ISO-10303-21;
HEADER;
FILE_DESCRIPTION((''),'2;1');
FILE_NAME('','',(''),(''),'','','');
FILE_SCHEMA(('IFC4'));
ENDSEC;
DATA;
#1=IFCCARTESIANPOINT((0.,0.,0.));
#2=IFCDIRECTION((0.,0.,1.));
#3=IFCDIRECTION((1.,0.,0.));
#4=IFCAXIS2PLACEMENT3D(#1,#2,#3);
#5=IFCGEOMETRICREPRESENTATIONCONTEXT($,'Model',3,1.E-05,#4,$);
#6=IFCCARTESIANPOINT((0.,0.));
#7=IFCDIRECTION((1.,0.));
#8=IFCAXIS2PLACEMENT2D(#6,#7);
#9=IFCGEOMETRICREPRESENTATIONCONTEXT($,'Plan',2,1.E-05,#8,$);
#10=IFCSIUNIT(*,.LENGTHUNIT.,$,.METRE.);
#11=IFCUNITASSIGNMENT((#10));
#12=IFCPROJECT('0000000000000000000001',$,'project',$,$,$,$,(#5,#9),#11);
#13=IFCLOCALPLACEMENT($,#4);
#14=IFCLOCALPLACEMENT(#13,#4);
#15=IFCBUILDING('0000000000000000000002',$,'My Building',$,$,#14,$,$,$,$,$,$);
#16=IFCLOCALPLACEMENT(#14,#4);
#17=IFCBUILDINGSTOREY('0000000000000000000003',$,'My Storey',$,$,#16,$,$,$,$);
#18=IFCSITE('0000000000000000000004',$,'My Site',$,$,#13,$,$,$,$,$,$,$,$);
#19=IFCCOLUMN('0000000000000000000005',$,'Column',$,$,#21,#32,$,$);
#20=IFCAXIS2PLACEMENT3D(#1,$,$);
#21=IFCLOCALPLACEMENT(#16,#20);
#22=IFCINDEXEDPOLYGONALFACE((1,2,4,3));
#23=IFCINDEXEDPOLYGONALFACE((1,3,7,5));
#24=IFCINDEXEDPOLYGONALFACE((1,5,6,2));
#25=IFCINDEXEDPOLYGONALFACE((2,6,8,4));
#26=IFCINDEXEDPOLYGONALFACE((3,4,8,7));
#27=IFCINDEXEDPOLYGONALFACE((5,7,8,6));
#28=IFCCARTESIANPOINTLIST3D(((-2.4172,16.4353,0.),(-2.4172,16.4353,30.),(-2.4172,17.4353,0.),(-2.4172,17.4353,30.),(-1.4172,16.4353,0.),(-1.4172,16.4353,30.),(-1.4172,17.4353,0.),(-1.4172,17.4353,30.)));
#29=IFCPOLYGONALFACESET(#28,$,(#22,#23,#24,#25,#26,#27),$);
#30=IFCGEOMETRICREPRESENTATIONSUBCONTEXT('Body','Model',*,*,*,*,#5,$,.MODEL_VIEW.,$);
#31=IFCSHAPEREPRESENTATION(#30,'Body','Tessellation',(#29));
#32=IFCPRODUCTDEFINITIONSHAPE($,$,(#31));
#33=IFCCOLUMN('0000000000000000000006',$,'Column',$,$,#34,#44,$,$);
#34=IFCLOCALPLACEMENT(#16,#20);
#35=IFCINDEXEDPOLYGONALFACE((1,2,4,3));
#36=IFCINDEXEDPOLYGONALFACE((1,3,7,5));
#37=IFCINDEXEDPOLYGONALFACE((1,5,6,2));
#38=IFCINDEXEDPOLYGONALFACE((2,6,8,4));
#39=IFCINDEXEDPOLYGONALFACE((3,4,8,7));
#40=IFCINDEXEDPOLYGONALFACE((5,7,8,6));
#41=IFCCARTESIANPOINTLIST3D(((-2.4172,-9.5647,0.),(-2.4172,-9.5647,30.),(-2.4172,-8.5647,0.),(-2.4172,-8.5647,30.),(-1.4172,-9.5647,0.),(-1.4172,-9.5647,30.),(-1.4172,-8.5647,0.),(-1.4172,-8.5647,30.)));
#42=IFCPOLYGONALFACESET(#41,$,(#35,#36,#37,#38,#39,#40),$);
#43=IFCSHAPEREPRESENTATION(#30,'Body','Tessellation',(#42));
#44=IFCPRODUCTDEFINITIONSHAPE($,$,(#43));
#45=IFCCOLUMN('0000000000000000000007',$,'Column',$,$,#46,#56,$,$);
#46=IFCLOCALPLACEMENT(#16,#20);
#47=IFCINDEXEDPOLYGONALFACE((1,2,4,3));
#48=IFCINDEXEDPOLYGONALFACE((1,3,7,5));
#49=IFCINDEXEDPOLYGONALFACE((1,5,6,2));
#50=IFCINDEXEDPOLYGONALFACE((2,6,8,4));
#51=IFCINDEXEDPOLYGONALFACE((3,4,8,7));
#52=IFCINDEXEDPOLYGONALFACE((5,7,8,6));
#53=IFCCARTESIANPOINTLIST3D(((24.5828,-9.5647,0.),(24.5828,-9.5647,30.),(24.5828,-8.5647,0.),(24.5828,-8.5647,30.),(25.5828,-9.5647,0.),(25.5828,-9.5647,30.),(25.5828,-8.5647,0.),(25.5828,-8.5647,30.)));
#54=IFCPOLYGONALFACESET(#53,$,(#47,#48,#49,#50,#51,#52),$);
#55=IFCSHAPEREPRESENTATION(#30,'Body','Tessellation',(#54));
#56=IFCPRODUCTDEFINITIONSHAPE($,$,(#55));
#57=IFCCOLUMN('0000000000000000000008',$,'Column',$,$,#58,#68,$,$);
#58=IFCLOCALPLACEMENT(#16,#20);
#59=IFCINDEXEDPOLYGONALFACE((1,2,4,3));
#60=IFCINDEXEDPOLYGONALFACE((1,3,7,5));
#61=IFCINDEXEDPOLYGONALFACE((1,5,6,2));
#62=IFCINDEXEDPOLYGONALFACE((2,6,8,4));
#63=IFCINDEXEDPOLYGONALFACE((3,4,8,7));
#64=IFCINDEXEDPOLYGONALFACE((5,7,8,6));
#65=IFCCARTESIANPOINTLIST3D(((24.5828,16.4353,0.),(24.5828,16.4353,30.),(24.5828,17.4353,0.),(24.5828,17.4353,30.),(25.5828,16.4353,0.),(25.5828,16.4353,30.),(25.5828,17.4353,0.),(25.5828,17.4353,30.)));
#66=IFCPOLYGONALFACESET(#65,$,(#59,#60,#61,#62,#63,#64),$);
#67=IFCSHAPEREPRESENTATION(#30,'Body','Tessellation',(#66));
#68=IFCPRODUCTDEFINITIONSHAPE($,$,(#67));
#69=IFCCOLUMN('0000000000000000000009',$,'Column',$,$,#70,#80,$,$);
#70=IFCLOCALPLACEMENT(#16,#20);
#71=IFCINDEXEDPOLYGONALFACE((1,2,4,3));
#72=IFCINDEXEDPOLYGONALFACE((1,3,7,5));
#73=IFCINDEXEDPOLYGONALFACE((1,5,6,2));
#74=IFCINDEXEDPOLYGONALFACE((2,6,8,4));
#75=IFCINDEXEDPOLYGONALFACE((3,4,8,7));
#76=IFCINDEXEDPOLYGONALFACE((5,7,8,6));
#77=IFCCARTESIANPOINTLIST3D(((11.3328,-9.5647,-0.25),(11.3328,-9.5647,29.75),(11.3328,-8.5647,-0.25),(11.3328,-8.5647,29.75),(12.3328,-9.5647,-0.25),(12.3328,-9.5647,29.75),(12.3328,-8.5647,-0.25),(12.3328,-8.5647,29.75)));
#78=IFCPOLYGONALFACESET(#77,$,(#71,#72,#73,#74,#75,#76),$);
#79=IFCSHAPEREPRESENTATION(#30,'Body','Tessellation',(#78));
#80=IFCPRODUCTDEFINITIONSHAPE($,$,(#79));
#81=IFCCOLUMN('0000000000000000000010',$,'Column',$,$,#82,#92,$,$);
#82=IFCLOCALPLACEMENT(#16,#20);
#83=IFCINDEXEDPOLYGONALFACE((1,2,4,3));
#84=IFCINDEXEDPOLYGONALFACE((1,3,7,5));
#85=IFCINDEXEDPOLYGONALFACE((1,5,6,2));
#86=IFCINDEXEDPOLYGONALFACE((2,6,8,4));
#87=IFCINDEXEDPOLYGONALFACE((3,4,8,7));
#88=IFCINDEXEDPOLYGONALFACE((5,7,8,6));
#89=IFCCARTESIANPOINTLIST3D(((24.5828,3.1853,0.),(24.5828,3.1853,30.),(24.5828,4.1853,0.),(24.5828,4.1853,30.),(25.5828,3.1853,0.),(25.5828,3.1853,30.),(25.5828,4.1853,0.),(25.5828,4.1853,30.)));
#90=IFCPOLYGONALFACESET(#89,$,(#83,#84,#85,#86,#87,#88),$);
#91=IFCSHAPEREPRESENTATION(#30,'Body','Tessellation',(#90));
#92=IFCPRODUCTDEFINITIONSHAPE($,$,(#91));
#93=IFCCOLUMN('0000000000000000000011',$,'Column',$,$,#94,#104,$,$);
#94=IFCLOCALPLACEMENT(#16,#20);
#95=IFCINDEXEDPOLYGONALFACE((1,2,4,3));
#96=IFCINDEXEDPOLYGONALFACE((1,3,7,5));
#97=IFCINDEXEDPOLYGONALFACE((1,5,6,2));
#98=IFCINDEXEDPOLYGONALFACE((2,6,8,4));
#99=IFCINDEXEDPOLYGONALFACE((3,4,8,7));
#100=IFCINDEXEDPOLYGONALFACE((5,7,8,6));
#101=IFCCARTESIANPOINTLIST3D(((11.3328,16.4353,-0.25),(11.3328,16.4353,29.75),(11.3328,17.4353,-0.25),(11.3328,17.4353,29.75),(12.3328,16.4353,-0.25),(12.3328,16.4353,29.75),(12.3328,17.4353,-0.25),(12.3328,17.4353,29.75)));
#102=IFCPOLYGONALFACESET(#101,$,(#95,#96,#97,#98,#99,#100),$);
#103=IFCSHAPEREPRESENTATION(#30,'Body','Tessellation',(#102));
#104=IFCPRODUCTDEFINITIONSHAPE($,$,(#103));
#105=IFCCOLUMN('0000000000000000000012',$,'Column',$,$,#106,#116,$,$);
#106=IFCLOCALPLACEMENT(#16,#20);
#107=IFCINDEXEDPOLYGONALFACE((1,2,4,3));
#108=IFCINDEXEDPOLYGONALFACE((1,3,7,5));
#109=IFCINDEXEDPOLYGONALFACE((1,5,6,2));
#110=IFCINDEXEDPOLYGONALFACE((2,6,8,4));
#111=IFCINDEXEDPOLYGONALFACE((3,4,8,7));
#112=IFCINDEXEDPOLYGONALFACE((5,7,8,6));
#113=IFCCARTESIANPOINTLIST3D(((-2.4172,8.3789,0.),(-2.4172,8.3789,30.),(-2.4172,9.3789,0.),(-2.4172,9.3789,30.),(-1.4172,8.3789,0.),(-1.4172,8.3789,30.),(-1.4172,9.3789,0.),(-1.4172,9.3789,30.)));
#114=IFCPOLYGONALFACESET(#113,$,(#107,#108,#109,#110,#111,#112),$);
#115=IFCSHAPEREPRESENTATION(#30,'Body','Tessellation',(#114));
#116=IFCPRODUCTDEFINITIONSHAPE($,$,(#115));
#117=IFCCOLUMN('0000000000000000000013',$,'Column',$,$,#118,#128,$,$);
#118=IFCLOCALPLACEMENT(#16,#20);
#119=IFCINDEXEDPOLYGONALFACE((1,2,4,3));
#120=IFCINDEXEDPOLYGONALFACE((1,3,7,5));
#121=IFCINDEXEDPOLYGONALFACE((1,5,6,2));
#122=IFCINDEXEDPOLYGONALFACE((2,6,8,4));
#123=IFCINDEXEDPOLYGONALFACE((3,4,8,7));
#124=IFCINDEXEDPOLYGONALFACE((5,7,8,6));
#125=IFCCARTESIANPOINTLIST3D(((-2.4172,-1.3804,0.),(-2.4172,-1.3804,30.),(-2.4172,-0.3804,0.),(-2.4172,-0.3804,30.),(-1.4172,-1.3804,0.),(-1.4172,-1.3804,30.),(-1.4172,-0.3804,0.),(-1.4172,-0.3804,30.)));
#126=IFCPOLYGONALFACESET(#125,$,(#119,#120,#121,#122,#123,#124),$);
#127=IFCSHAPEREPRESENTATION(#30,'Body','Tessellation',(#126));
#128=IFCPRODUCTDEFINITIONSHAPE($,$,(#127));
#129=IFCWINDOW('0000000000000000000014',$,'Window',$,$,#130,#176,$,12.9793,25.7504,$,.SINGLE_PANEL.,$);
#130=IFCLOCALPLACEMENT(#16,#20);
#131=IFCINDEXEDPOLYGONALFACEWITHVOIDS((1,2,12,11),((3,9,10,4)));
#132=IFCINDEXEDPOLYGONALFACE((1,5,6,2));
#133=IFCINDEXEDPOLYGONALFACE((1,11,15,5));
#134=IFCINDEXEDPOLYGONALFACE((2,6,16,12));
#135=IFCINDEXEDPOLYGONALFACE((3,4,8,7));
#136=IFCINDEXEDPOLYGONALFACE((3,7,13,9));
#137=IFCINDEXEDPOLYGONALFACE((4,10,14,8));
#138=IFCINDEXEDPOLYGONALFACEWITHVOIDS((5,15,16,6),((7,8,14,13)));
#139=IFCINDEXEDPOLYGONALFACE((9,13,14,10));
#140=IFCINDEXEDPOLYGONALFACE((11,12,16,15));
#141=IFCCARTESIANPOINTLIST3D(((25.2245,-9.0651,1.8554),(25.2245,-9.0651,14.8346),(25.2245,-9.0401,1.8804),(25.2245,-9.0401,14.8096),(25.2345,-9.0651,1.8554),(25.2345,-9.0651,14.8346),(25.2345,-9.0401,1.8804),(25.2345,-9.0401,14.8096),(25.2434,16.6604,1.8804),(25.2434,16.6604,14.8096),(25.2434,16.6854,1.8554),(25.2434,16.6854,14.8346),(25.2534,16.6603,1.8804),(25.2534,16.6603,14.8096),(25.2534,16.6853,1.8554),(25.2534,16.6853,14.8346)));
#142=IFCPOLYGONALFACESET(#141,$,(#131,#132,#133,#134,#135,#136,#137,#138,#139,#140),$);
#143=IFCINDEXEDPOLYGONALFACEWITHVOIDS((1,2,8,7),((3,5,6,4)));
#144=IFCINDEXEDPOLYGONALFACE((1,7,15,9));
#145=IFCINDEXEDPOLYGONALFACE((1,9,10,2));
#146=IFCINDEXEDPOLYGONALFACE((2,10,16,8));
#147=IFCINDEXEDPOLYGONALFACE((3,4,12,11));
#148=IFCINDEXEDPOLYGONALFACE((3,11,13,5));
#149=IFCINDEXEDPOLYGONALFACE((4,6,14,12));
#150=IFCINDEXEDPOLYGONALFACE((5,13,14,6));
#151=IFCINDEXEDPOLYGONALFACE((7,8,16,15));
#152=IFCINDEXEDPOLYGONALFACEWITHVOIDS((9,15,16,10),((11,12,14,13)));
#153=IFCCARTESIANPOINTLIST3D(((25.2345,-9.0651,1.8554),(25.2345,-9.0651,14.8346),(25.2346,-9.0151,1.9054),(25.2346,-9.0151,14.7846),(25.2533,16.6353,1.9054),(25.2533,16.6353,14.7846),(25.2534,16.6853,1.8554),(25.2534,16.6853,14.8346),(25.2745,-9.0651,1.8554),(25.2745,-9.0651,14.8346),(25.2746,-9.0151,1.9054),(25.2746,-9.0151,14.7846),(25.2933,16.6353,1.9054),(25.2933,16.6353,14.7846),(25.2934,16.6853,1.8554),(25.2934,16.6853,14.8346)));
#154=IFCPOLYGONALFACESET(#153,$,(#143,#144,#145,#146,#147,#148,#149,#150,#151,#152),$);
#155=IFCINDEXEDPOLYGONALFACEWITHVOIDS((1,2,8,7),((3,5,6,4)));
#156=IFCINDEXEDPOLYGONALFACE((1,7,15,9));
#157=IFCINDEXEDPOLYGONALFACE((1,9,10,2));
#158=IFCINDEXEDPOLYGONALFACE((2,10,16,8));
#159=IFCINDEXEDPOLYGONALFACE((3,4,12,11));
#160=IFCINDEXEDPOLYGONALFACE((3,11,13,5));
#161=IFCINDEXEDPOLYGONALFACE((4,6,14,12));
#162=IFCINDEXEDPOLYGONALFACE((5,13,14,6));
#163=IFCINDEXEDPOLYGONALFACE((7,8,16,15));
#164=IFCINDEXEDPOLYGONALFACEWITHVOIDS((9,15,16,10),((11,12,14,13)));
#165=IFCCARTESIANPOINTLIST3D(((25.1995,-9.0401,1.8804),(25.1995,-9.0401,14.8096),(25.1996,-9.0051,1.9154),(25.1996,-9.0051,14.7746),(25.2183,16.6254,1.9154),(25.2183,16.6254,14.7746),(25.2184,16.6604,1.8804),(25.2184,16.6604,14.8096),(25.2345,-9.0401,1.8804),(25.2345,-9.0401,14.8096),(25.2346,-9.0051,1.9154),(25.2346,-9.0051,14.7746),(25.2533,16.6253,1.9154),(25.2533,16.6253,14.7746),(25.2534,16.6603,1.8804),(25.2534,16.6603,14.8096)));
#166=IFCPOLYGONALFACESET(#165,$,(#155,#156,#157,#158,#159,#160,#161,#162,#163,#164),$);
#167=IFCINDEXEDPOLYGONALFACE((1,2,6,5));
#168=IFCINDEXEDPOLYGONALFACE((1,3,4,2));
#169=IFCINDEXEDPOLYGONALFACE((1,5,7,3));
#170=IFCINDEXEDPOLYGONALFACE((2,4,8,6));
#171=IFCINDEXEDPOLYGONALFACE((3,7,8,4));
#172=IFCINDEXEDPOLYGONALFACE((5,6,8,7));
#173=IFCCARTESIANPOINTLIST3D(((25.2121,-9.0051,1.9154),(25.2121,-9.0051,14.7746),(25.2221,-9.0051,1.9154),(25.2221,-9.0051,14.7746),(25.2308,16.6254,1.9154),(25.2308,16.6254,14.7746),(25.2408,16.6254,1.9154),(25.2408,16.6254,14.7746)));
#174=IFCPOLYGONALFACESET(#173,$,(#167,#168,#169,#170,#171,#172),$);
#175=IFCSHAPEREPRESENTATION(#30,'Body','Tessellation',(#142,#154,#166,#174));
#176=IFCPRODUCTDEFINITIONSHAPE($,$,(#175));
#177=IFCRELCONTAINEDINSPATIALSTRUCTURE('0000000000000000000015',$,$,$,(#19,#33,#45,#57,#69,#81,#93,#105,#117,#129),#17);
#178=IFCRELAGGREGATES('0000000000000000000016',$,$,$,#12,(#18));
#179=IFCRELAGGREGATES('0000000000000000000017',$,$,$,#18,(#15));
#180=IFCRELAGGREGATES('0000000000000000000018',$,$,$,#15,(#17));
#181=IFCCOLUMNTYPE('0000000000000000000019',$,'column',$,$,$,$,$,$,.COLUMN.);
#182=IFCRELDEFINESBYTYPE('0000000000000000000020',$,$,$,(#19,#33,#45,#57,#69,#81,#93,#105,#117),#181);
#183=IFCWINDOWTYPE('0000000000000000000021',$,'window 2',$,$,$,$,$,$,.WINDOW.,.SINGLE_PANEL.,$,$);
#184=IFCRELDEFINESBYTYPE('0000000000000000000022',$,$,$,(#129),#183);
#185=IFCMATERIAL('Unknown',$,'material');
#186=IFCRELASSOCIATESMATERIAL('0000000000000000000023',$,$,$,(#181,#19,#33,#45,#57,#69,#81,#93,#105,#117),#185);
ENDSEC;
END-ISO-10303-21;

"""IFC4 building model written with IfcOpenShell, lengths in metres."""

from ifc_helpers import new_model, entity, si_unit, frame, origin_with_axes, origin_2d_with_axis, place, context, subcontext, project, spatial, line, indexed_curve, rectangle, outline, extrude, shape, source, transform, mapped, material, material_profile, profile_set, profile_usage, type_object, type_shapes, element, save


model = new_model("IFC4")

# Units and contexts
model_context = context("Model", 3, precision=1e-05, world=origin_with_axes())
plan_context = context("Plan", 2, precision=1e-05, world=origin_2d_with_axis())
body_context_1 = subcontext(model_context, "Body", "Model", "MODEL_VIEW")
body_context_2 = subcontext(plan_context, "Body", "Plan", "PLAN_VIEW")
ifc_project = project(units=[si_unit("LENGTHUNIT", "METRE")], contexts=[model_context, plan_context])

# Site, building, storey
site_placement = place(None, origin_with_axes())
site = spatial("IfcSite", under=ifc_project, at=site_placement, Name="My Site")
building_placement = place(site_placement, origin_with_axes())
building = spatial("IfcBuilding", under=site, at=building_placement, Name="My Building")
storey_placement = place(building_placement, origin_with_axes())
storey = spatial("IfcBuildingStorey", under=building, at=storey_placement, Name="My Storey")

# Columns
ifc_material = material(Name="Unknown", Category="material")
ifc_material_profile = material_profile(ifc_material, rectangle(XDim=1.0, YDim=1.0))
ifc_profile_set = profile_set([ifc_material_profile])
ifc_profile_usage_1 = profile_usage(ifc_profile_set, cardinal=5)
column_type = type_object("IfcColumnType", Name="column", PredefinedType="COLUMN", material=ifc_profile_set)
column_1_placement = place(storey_placement, frame((-1.9172, 16.9353, 0.0), z_axis=(0.0, 0.0, 1.0), x_axis=(1.0, 0.0, 0.0)))
element("IfcColumn", 1, at=column_1_placement, inside=storey, type_object=column_type, material=ifc_profile_usage_1, Name="Column", context=body_context_1, shape_type="SweptSolid", body=[
    extrude(rectangle(XDim=1.0, YDim=1.0), origin_with_axes(), (0.0, 0.0, 1.0), 30.0),
])
ifc_profile_usage_2 = profile_usage(ifc_profile_set, cardinal=5)
column_2_placement = place(storey_placement, frame((-1.9172, -9.0647, 0.0), z_axis=(0.0, 0.0, 1.0), x_axis=(1.0, 0.0, 0.0)))
element("IfcColumn", 2, at=column_2_placement, inside=storey, type_object=column_type, material=ifc_profile_usage_2, Name="Column", context=body_context_1, shape_type="SweptSolid", body=[
    extrude(rectangle(XDim=1.0, YDim=1.0), origin_with_axes(), (0.0, 0.0, 1.0), 30.0),
])
ifc_profile_usage_3 = profile_usage(ifc_profile_set, cardinal=5)
column_3_placement = place(storey_placement, frame((25.0828, -9.0647, 0.0), z_axis=(0.0, 0.0, 1.0), x_axis=(1.0, 0.0, 0.0)))
element("IfcColumn", 3, at=column_3_placement, inside=storey, type_object=column_type, material=ifc_profile_usage_3, Name="Column", context=body_context_1, shape_type="SweptSolid", body=[
    extrude(rectangle(XDim=1.0, YDim=1.0), origin_with_axes(), (0.0, 0.0, 1.0), 30.0),
])
ifc_profile_usage_4 = profile_usage(ifc_profile_set, cardinal=5)
column_4_placement = place(storey_placement, frame((25.0828, 16.9353, 0.0), z_axis=(0.0, 0.0, 1.0), x_axis=(1.0, 0.0, 0.0)))
element("IfcColumn", 4, at=column_4_placement, inside=storey, type_object=column_type, material=ifc_profile_usage_4, Name="Column", context=body_context_1, shape_type="SweptSolid", body=[
    extrude(rectangle(XDim=1.0, YDim=1.0), origin_with_axes(), (0.0, 0.0, 1.0), 30.0),
])
ifc_profile_usage_5 = profile_usage(ifc_profile_set, cardinal=5)
column_5_placement = place(storey_placement, frame((11.8328, -9.0647, -0.25), z_axis=(0.0, 0.0, 1.0), x_axis=(1.0, 0.0, 0.0)))
element("IfcColumn", 5, at=column_5_placement, inside=storey, type_object=column_type, material=ifc_profile_usage_5, Name="Column", context=body_context_1, shape_type="SweptSolid", body=[
    extrude(rectangle(XDim=1.0, YDim=1.0), origin_with_axes(), (0.0, 0.0, 1.0), 30.0),
])
ifc_profile_usage_6 = profile_usage(ifc_profile_set, cardinal=5)
column_6_placement = place(storey_placement, frame((25.0828, 3.6853, 0.0), z_axis=(0.0, 0.0, 1.0), x_axis=(1.0, 0.0, 0.0)))
element("IfcColumn", 6, at=column_6_placement, inside=storey, type_object=column_type, material=ifc_profile_usage_6, Name="Column", context=body_context_1, shape_type="SweptSolid", body=[
    extrude(rectangle(XDim=1.0, YDim=1.0), origin_with_axes(), (0.0, 0.0, 1.0), 30.0),
])
ifc_profile_usage_7 = profile_usage(ifc_profile_set, cardinal=5)
column_7_placement = place(storey_placement, frame((11.8328, 16.9353, -0.25), z_axis=(0.0, 0.0, 1.0), x_axis=(1.0, 0.0, 0.0)))
element("IfcColumn", 7, at=column_7_placement, inside=storey, type_object=column_type, material=ifc_profile_usage_7, Name="Column", context=body_context_1, shape_type="SweptSolid", body=[
    extrude(rectangle(XDim=1.0, YDim=1.0), origin_with_axes(), (0.0, 0.0, 1.0), 30.0),
])
ifc_profile_usage_8 = profile_usage(ifc_profile_set, cardinal=5)
column_8_placement = place(storey_placement, frame((-1.9172, 8.8789, 0.0), z_axis=(0.0, 0.0, 1.0), x_axis=(1.0, 0.0, 0.0)))
element("IfcColumn", 8, at=column_8_placement, inside=storey, type_object=column_type, material=ifc_profile_usage_8, Name="Column", context=body_context_1, shape_type="SweptSolid", body=[
    extrude(rectangle(XDim=1.0, YDim=1.0), origin_with_axes(), (0.0, 0.0, 1.0), 30.0),
])
ifc_profile_usage_9 = profile_usage(ifc_profile_set, cardinal=5)
column_9_placement = place(storey_placement, frame((-1.9172, -0.8804, 0.0), z_axis=(0.0, 0.0, 1.0), x_axis=(1.0, 0.0, 0.0)))
element("IfcColumn", 9, at=column_9_placement, inside=storey, type_object=column_type, material=ifc_profile_usage_9, Name="Column", context=body_context_1, shape_type="SweptSolid", body=[
    extrude(rectangle(XDim=1.0, YDim=1.0), origin_with_axes(), (0.0, 0.0, 1.0), 30.0),
])

# Window
window_type_1 = type_object("IfcWindowType", Name="window 2", PartitioningType="SINGLE_PANEL", PredefinedType="WINDOW")
shared_shape_1 = source(origin_with_axes(), body_context_1, "Body", "SweptSolid", [
    extrude(outline(indexed_curve([(0.0, 0.0), (25.7504, 0.0), (25.7504, 12.9793), (0.0, 12.9793)], segments=[line(1, 2, 3, 4, 1)]), holes=[indexed_curve([(0.025, 0.025), (25.7254, 0.025), (25.7254, 12.9543), (0.025, 12.9543)], segments=[line(1, 2, 3, 4, 1)])]), frame((0.0, 0.09, 0.0), z_axis=(0.0, -1.0, 0.0), x_axis=(1.0, 0.0, 0.0)), (0.0, 0.0, -1.0), 0.01),
    extrude(outline(indexed_curve([(0.0, 0.0), (25.7504, 0.0), (25.7504, 12.9793), (0.0, 12.9793)], segments=[line(1, 2, 3, 4, 1)]), holes=[indexed_curve([(0.05, 0.05), (25.7004, 0.05), (25.7004, 12.9293), (0.05, 12.9293)], segments=[line(1, 2, 3, 4, 1)])]), frame((0.0, 0.05, 0.0), z_axis=(0.0, -1.0, 0.0), x_axis=(1.0, 0.0, 0.0)), (0.0, 0.0, -1.0), 0.04),
    extrude(outline(indexed_curve([(0.0, 0.0), (25.7004, 0.0), (25.7004, 12.9293), (0.0, 12.9293)], segments=[line(1, 2, 3, 4, 1)]), holes=[indexed_curve([(0.035, 0.035), (25.6654, 0.035), (25.6654, 12.8943), (0.035, 12.8943)], segments=[line(1, 2, 3, 4, 1)])]), frame((0.025, 0.09, 0.025), z_axis=(0.0, -1.0, 0.0), x_axis=(1.0, 0.0, 0.0)), (0.0, 0.0, -1.0), 0.035),
    extrude(outline(indexed_curve([(0.035, 0.035), (25.6654, 0.035), (25.6654, 12.8943), (0.035, 12.8943)], segments=[line(1, 2, 3, 4, 1)])), frame((0.025, 0.1025, 0.025), z_axis=(0.0, -1.0, 0.0), x_axis=(1.0, 0.0, 0.0)), (0.0, 0.0, -1.0), 0.01),
])
shared_shape_2 = source(origin_with_axes(), body_context_2, "Body", "Curve2D", [
    entity("IfcIndexedPolyCurve", entity("IfcCartesianPointList2D", [[0.05, 0.05], [25.7004, 0.05]])),
    entity("IfcIndexedPolyCurve", entity("IfcCartesianPointList2D", [[0.0, 0.1], [0.025, 0.1], [0.025, 0.09], [0.05, 0.09], [0.05, 0.05], [0.0, 0.05]]), [entity("IfcLineIndex", [1, 2, 3, 4, 5, 6, 1])]),
    entity("IfcIndexedPolyCurve", entity("IfcCartesianPointList2D", [[25.7504, 0.1], [25.7254, 0.1], [25.7254, 0.09], [25.7004, 0.09], [25.7004, 0.05], [25.7504, 0.05]]), [entity("IfcLineIndex", [1, 2, 3, 4, 5, 6, 1])]),
    entity("IfcIndexedPolyCurve", entity("IfcCartesianPointList2D", [[0.025, 0.09], [0.06, 0.09], [0.06, 0.125], [0.025, 0.125]]), [entity("IfcLineIndex", [1, 2, 3, 4, 1])]),
    entity("IfcIndexedPolyCurve", entity("IfcCartesianPointList2D", [[25.7254, 0.09], [25.6904, 0.09], [25.6904, 0.125], [25.7254, 0.125]]), [entity("IfcLineIndex", [1, 2, 3, 4, 1])]),
    entity("IfcIndexedPolyCurve", entity("IfcCartesianPointList2D", [[0.06, 0.09], [25.6904, 0.09]])),
    entity("IfcIndexedPolyCurve", entity("IfcCartesianPointList2D", [[0.06, 0.125], [25.6904, 0.125]])),
    entity("IfcIndexedPolyCurve", entity("IfcCartesianPointList2D", [[0.06, 0.1075], [25.6904, 0.1075]])),
])
type_shapes(window_type_1, [shared_shape_1, shared_shape_2])
window_placement = place(storey_placement, frame((25.3245, -9.0652, 1.8554), z_axis=(0.0, 0.0, 1.0), x_axis=(0.000732, 1.0, 0.0)))
element("IfcWindow", 10, at=window_placement, inside=storey, type_object=window_type_1, Name="Window", OverallHeight=12.9793, OverallWidth=25.7504, PartitioningType="SINGLE_PANEL", shapes=[
    shape(body_context_1, "Body", "MappedRepresentation", [mapped(shared_shape_1, transform((0.0, 0.0, 0.0), x_axis=(1.0, 0.0, 0.0), y_axis=(0.0, 1.0, 0.0), z_axis=(0.0, 0.0, 1.0), scale=1.0))]),
    shape(body_context_2, "Body", "MappedRepresentation", [mapped(shared_shape_2, transform((0.0, 0.0, 0.0), x_axis=(1.0, 0.0, 0.0), y_axis=(0.0, 1.0, 0.0), z_axis=(0.0, 0.0, 1.0), scale=1.0))]),
])

save(model, "model.ifc")
